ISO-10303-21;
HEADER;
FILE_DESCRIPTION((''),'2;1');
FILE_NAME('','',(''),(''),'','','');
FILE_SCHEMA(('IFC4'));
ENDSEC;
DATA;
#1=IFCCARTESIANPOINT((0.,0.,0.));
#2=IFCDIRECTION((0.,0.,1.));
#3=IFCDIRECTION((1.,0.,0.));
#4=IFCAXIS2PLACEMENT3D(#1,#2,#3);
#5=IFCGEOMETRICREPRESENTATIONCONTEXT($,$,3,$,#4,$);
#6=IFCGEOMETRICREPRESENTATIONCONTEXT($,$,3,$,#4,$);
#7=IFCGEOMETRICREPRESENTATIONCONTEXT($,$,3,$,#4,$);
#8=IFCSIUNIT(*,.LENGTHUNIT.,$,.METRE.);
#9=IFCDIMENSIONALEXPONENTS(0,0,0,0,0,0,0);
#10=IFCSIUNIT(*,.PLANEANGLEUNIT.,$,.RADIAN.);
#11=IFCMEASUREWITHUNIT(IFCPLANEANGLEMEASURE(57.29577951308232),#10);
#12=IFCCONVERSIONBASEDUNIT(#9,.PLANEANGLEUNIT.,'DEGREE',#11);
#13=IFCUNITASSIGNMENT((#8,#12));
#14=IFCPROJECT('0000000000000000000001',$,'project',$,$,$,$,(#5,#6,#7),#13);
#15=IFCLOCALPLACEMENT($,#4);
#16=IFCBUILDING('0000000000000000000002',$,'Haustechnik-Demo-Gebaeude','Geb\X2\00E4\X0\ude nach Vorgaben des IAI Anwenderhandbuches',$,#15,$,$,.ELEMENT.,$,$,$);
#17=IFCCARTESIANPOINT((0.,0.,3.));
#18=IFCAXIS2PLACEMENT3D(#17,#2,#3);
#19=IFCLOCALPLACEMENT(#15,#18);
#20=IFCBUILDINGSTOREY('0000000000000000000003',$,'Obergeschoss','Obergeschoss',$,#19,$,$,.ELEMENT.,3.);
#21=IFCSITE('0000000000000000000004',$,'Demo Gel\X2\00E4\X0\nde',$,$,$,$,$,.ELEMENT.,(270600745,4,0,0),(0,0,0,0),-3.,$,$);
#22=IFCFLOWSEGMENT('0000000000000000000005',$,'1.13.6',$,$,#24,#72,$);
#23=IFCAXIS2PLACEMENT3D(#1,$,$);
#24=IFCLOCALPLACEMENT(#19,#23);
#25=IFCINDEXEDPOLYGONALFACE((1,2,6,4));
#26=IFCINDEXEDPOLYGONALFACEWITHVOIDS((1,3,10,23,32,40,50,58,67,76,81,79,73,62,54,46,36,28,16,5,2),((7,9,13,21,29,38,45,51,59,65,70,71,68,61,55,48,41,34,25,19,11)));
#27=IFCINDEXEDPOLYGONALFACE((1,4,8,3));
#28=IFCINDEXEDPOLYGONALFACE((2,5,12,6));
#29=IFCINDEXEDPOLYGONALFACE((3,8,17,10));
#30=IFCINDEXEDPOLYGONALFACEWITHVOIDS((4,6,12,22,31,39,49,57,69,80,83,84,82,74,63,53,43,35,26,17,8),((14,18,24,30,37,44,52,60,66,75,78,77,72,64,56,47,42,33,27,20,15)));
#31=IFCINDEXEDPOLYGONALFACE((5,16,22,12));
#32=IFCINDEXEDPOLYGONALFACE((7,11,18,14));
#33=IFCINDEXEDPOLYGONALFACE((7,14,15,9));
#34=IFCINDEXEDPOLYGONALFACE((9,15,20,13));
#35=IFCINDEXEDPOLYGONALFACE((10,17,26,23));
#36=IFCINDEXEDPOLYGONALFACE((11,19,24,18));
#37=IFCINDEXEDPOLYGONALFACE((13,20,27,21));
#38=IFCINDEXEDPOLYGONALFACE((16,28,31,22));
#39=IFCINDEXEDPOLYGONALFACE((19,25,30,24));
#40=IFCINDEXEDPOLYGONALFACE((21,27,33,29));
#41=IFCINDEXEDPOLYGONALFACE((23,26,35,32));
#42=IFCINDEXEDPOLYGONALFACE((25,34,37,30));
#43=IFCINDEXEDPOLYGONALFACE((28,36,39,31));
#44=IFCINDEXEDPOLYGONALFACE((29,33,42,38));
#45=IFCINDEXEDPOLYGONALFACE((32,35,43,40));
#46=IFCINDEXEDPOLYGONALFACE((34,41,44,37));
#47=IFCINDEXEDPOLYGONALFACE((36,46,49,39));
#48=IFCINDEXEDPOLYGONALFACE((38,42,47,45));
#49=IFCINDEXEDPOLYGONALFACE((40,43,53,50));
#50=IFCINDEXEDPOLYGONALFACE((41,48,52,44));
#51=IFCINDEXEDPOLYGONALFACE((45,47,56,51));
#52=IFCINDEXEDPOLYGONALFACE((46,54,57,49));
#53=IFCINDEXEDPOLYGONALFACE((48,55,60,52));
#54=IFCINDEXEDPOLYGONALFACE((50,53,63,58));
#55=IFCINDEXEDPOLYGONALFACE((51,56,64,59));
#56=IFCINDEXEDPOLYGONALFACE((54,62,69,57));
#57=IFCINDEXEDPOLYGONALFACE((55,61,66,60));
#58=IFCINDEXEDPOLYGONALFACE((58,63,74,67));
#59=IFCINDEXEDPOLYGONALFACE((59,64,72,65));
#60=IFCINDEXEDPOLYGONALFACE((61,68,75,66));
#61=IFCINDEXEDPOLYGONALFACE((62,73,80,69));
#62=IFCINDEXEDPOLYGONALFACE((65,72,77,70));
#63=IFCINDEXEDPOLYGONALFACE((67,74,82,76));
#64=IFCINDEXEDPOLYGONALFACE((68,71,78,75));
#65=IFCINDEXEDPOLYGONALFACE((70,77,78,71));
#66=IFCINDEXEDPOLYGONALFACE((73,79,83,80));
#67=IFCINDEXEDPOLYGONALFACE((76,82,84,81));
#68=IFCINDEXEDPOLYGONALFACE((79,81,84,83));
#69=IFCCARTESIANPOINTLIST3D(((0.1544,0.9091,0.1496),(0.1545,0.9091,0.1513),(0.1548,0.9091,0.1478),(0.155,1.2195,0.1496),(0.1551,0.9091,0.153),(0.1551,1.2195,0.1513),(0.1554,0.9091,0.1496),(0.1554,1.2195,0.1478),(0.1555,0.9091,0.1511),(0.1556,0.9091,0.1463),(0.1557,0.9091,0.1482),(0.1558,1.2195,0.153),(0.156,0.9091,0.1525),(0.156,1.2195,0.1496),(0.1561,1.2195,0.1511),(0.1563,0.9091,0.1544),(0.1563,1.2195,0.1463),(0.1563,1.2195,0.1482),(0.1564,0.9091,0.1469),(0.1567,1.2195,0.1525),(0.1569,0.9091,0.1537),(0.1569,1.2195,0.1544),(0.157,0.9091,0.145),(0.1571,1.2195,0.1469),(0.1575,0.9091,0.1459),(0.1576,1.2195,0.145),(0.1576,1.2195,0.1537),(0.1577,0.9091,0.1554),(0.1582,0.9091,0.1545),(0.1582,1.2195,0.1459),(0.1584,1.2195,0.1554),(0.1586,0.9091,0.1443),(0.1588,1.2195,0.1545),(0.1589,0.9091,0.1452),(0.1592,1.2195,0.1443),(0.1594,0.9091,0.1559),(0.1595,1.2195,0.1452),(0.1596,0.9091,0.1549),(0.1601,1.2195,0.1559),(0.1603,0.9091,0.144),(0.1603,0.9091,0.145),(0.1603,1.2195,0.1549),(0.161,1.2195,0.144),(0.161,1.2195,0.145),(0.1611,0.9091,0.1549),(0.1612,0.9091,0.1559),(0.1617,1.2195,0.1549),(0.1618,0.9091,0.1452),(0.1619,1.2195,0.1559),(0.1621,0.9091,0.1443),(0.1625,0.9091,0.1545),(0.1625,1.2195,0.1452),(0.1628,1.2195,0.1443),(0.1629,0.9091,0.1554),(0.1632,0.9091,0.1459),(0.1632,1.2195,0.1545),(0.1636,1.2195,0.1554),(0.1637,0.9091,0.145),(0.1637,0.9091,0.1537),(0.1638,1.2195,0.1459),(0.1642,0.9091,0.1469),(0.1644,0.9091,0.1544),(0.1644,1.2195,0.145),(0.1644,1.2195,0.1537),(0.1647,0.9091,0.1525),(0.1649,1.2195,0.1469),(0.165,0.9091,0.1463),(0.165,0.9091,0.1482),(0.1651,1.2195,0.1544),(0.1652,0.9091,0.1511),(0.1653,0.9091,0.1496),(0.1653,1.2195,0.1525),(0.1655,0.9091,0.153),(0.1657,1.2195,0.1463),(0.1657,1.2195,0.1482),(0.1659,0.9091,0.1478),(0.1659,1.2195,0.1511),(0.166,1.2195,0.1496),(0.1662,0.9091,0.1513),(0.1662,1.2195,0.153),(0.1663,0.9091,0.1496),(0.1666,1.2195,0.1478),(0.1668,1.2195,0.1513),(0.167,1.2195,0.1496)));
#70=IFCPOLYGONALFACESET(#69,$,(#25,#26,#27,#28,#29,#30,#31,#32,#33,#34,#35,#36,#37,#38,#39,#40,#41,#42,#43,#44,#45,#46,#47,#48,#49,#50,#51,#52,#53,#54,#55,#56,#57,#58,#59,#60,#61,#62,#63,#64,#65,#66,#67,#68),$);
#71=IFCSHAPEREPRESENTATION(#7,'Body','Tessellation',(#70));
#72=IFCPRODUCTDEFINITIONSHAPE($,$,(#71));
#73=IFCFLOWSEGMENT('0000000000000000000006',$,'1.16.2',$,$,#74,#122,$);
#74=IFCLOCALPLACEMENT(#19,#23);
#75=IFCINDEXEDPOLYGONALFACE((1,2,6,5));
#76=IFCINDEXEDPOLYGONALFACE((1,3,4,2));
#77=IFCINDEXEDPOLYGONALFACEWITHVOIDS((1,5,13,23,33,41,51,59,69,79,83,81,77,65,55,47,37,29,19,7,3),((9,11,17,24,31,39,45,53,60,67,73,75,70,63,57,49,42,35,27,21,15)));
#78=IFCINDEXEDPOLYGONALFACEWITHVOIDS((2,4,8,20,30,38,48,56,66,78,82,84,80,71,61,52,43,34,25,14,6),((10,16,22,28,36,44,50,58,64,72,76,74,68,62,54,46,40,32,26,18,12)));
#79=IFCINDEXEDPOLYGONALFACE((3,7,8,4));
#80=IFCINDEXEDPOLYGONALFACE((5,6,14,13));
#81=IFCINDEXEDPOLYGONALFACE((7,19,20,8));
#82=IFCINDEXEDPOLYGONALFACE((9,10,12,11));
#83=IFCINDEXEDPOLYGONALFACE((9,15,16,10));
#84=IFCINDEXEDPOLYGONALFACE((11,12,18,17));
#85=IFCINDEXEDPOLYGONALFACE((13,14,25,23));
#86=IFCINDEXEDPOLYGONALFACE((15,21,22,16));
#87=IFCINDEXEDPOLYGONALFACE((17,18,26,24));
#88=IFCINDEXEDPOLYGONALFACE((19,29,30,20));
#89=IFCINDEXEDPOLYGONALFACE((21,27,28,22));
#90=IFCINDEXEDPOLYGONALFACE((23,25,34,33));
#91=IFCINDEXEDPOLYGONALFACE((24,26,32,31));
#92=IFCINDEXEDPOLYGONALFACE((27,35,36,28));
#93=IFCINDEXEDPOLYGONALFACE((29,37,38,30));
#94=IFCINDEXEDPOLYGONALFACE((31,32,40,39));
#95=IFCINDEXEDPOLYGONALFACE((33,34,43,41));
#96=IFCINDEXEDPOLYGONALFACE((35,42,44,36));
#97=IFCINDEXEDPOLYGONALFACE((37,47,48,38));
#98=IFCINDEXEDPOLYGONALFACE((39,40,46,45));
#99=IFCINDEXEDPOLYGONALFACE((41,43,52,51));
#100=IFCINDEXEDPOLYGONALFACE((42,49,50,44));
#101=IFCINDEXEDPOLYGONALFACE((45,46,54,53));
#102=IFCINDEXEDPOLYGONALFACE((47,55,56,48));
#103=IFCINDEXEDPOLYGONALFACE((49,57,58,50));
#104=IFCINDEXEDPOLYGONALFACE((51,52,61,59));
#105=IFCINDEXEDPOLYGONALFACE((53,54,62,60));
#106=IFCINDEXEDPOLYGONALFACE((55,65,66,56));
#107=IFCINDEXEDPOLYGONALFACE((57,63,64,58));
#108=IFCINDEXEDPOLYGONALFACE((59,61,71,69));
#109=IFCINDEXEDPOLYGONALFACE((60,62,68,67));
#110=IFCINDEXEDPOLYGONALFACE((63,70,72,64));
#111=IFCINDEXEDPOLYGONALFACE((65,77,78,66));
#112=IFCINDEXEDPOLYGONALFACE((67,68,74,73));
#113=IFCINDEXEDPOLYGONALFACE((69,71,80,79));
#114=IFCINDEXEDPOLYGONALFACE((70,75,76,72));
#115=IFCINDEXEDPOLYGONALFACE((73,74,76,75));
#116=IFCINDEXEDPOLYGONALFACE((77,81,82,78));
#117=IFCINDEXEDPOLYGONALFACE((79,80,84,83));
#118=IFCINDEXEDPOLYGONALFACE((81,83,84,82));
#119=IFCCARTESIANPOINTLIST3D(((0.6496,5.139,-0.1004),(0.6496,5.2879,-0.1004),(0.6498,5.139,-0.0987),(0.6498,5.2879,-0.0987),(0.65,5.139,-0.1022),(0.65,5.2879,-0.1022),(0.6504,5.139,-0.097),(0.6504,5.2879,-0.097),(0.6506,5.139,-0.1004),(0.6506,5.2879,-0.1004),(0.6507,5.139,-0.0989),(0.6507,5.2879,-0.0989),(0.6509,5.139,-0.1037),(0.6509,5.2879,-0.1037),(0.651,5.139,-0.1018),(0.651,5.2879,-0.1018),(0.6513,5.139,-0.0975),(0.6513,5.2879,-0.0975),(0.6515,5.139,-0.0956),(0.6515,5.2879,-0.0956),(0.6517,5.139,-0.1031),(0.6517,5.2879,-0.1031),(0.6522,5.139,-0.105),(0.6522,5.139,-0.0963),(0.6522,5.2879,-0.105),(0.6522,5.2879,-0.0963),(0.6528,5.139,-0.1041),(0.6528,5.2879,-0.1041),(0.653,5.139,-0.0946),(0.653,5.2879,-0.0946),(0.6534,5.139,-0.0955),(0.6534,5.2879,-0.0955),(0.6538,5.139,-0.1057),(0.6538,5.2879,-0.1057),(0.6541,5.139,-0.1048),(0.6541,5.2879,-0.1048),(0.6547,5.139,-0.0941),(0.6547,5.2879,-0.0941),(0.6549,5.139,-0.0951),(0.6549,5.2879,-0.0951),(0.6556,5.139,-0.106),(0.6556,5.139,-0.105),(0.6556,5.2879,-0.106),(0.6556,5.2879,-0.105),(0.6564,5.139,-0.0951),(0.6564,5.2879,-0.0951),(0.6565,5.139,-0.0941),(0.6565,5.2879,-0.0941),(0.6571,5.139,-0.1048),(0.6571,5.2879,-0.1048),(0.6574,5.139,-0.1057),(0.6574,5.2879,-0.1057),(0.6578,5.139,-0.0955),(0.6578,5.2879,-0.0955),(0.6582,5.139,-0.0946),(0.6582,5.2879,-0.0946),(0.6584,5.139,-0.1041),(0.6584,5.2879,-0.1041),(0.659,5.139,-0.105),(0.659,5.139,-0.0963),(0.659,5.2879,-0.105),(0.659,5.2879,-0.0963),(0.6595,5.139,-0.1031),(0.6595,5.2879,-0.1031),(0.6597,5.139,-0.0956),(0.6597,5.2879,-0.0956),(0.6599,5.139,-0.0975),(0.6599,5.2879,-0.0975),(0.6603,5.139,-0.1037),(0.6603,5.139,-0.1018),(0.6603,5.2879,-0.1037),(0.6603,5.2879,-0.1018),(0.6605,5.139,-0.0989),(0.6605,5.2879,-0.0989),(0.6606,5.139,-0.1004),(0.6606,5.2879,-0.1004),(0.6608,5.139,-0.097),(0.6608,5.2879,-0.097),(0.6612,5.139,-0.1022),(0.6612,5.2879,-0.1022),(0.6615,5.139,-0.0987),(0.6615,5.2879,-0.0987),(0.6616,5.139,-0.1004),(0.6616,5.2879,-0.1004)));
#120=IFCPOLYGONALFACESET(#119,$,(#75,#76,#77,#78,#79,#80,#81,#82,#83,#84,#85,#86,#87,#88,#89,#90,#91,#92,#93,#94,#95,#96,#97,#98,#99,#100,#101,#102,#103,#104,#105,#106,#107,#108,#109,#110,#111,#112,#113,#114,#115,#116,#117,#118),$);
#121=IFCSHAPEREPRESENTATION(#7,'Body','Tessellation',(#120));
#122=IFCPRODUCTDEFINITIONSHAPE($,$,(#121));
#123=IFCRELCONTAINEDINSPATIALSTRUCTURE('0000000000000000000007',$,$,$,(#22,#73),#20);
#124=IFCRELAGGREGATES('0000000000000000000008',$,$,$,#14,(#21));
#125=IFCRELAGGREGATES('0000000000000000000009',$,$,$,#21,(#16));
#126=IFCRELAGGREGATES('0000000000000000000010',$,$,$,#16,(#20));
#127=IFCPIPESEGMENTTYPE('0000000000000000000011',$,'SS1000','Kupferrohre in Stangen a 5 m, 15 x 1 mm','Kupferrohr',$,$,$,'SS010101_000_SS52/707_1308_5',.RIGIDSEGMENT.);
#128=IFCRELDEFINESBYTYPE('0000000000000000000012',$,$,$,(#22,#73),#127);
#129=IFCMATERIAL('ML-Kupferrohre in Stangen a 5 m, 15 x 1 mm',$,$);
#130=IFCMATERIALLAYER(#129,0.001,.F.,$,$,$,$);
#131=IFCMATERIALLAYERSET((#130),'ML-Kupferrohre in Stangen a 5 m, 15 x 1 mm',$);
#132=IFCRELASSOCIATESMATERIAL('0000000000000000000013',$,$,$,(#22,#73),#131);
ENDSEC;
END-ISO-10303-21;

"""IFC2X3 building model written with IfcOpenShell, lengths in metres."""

from ifc_helpers import new_model, entity, si_unit, converted_unit, frame, origin_with_axes, origin_2d_with_axis, place, context, project, spatial, hollow_circle, extrude, material, layer, layer_set, layer_usage, type_object, element, save


model = new_model("IFC2X3")

# Units and contexts
context_of_model_1 = context(None, 3, world=origin_with_axes())
context_of_model_2 = context(None, 3, world=origin_with_axes())
context_of_model_3 = context(None, 3, world=origin_with_axes())
ifc_project = project(units=[si_unit("LENGTHUNIT", "METRE"), converted_unit("PLANEANGLEUNIT", "DEGREE", entity("IfcPlaneAngleMeasure", 57.29577951308232), si_unit("PLANEANGLEUNIT", "RADIAN"), dimensions=[0, 0, 0, 0, 0, 0, 0])], contexts=[context_of_model_1, context_of_model_2, context_of_model_3])

# Site, building, storey
site = spatial("IfcSite", under=ifc_project, Name="Demo Gelände", CompositionType="ELEMENT", RefLatitude=(270600745, 4, 0, 0), RefLongitude=(0, 0, 0, 0), RefElevation=-3.0)
building_placement = place(None, origin_with_axes())
building = spatial("IfcBuilding", under=site, at=building_placement, Name="Haustechnik-Demo-Gebaeude", Description="Gebäude nach Vorgaben des IAI Anwenderhandbuches", CompositionType="ELEMENT")
storey_placement = place(building_placement, frame((0.0, 0.0, 3.0), z_axis=(0.0, 0.0, 1.0), x_axis=(1.0, 0.0, 0.0)))
storey = spatial("IfcBuildingStorey", under=building, at=storey_placement, Name="Obergeschoss", Description="Obergeschoss", CompositionType="ELEMENT", Elevation=3.0)

# Flow segments
ifc_material = material(Name="ML-Kupferrohre in Stangen a 5 m, 15 x 1 mm")
ifc_layer = layer(ifc_material, 0.001, ventilated=False)
ifc_layer_set = layer_set([ifc_layer], Name="ML-Kupferrohre in Stangen a 5 m, 15 x 1 mm")
ifc_layer_usage = layer_usage(ifc_layer_set, "AXIS2", "POSITIVE", 0.0)
pipe_segment_type_1 = type_object("IfcPipeSegmentType", Name="SS1000", Description="Kupferrohre in Stangen a 5 m, 15 x 1 mm", ApplicableOccurrence="Kupferrohr", ElementType="SS010101_000_SS52/707_1308_5", PredefinedType="RIGIDSEGMENT")
flow_segment_1_placement = place(storey_placement, frame((0.1603, 0.9091, 0.15), z_axis=(0.002134, 0.999998, 0.0), x_axis=(0.0, 0.0, -1.0)))
element("IfcFlowSegment", 1, at=flow_segment_1_placement, inside=storey, type_object=pipe_segment_type_1, material=ifc_layer_usage, Name="1.13.6", context=context_of_model_3, shape_type="SweptSolid", body=[
    extrude(hollow_circle(Radius=0.006, WallThickness=0.001, at=origin_2d_with_axis()), origin_with_axes(), (0.0, 0.0, 1.0), 0.3104),
])
flow_segment_2_placement = place(storey_placement, frame((0.6556, 5.139, -0.1), z_axis=(0.0, 1.0, 0.0), x_axis=(0.0, 0.0, -1.0)))
element("IfcFlowSegment", 2, at=flow_segment_2_placement, inside=storey, type_object=pipe_segment_type_1, material=ifc_layer_usage, Name="1.16.2", context=context_of_model_3, shape_type="SweptSolid", body=[
    extrude(hollow_circle(Radius=0.006, WallThickness=0.001, at=origin_2d_with_axis()), origin_with_axes(), (0.0, 0.0, 1.0), 0.1489),
])

save(model, "model.ifc")
